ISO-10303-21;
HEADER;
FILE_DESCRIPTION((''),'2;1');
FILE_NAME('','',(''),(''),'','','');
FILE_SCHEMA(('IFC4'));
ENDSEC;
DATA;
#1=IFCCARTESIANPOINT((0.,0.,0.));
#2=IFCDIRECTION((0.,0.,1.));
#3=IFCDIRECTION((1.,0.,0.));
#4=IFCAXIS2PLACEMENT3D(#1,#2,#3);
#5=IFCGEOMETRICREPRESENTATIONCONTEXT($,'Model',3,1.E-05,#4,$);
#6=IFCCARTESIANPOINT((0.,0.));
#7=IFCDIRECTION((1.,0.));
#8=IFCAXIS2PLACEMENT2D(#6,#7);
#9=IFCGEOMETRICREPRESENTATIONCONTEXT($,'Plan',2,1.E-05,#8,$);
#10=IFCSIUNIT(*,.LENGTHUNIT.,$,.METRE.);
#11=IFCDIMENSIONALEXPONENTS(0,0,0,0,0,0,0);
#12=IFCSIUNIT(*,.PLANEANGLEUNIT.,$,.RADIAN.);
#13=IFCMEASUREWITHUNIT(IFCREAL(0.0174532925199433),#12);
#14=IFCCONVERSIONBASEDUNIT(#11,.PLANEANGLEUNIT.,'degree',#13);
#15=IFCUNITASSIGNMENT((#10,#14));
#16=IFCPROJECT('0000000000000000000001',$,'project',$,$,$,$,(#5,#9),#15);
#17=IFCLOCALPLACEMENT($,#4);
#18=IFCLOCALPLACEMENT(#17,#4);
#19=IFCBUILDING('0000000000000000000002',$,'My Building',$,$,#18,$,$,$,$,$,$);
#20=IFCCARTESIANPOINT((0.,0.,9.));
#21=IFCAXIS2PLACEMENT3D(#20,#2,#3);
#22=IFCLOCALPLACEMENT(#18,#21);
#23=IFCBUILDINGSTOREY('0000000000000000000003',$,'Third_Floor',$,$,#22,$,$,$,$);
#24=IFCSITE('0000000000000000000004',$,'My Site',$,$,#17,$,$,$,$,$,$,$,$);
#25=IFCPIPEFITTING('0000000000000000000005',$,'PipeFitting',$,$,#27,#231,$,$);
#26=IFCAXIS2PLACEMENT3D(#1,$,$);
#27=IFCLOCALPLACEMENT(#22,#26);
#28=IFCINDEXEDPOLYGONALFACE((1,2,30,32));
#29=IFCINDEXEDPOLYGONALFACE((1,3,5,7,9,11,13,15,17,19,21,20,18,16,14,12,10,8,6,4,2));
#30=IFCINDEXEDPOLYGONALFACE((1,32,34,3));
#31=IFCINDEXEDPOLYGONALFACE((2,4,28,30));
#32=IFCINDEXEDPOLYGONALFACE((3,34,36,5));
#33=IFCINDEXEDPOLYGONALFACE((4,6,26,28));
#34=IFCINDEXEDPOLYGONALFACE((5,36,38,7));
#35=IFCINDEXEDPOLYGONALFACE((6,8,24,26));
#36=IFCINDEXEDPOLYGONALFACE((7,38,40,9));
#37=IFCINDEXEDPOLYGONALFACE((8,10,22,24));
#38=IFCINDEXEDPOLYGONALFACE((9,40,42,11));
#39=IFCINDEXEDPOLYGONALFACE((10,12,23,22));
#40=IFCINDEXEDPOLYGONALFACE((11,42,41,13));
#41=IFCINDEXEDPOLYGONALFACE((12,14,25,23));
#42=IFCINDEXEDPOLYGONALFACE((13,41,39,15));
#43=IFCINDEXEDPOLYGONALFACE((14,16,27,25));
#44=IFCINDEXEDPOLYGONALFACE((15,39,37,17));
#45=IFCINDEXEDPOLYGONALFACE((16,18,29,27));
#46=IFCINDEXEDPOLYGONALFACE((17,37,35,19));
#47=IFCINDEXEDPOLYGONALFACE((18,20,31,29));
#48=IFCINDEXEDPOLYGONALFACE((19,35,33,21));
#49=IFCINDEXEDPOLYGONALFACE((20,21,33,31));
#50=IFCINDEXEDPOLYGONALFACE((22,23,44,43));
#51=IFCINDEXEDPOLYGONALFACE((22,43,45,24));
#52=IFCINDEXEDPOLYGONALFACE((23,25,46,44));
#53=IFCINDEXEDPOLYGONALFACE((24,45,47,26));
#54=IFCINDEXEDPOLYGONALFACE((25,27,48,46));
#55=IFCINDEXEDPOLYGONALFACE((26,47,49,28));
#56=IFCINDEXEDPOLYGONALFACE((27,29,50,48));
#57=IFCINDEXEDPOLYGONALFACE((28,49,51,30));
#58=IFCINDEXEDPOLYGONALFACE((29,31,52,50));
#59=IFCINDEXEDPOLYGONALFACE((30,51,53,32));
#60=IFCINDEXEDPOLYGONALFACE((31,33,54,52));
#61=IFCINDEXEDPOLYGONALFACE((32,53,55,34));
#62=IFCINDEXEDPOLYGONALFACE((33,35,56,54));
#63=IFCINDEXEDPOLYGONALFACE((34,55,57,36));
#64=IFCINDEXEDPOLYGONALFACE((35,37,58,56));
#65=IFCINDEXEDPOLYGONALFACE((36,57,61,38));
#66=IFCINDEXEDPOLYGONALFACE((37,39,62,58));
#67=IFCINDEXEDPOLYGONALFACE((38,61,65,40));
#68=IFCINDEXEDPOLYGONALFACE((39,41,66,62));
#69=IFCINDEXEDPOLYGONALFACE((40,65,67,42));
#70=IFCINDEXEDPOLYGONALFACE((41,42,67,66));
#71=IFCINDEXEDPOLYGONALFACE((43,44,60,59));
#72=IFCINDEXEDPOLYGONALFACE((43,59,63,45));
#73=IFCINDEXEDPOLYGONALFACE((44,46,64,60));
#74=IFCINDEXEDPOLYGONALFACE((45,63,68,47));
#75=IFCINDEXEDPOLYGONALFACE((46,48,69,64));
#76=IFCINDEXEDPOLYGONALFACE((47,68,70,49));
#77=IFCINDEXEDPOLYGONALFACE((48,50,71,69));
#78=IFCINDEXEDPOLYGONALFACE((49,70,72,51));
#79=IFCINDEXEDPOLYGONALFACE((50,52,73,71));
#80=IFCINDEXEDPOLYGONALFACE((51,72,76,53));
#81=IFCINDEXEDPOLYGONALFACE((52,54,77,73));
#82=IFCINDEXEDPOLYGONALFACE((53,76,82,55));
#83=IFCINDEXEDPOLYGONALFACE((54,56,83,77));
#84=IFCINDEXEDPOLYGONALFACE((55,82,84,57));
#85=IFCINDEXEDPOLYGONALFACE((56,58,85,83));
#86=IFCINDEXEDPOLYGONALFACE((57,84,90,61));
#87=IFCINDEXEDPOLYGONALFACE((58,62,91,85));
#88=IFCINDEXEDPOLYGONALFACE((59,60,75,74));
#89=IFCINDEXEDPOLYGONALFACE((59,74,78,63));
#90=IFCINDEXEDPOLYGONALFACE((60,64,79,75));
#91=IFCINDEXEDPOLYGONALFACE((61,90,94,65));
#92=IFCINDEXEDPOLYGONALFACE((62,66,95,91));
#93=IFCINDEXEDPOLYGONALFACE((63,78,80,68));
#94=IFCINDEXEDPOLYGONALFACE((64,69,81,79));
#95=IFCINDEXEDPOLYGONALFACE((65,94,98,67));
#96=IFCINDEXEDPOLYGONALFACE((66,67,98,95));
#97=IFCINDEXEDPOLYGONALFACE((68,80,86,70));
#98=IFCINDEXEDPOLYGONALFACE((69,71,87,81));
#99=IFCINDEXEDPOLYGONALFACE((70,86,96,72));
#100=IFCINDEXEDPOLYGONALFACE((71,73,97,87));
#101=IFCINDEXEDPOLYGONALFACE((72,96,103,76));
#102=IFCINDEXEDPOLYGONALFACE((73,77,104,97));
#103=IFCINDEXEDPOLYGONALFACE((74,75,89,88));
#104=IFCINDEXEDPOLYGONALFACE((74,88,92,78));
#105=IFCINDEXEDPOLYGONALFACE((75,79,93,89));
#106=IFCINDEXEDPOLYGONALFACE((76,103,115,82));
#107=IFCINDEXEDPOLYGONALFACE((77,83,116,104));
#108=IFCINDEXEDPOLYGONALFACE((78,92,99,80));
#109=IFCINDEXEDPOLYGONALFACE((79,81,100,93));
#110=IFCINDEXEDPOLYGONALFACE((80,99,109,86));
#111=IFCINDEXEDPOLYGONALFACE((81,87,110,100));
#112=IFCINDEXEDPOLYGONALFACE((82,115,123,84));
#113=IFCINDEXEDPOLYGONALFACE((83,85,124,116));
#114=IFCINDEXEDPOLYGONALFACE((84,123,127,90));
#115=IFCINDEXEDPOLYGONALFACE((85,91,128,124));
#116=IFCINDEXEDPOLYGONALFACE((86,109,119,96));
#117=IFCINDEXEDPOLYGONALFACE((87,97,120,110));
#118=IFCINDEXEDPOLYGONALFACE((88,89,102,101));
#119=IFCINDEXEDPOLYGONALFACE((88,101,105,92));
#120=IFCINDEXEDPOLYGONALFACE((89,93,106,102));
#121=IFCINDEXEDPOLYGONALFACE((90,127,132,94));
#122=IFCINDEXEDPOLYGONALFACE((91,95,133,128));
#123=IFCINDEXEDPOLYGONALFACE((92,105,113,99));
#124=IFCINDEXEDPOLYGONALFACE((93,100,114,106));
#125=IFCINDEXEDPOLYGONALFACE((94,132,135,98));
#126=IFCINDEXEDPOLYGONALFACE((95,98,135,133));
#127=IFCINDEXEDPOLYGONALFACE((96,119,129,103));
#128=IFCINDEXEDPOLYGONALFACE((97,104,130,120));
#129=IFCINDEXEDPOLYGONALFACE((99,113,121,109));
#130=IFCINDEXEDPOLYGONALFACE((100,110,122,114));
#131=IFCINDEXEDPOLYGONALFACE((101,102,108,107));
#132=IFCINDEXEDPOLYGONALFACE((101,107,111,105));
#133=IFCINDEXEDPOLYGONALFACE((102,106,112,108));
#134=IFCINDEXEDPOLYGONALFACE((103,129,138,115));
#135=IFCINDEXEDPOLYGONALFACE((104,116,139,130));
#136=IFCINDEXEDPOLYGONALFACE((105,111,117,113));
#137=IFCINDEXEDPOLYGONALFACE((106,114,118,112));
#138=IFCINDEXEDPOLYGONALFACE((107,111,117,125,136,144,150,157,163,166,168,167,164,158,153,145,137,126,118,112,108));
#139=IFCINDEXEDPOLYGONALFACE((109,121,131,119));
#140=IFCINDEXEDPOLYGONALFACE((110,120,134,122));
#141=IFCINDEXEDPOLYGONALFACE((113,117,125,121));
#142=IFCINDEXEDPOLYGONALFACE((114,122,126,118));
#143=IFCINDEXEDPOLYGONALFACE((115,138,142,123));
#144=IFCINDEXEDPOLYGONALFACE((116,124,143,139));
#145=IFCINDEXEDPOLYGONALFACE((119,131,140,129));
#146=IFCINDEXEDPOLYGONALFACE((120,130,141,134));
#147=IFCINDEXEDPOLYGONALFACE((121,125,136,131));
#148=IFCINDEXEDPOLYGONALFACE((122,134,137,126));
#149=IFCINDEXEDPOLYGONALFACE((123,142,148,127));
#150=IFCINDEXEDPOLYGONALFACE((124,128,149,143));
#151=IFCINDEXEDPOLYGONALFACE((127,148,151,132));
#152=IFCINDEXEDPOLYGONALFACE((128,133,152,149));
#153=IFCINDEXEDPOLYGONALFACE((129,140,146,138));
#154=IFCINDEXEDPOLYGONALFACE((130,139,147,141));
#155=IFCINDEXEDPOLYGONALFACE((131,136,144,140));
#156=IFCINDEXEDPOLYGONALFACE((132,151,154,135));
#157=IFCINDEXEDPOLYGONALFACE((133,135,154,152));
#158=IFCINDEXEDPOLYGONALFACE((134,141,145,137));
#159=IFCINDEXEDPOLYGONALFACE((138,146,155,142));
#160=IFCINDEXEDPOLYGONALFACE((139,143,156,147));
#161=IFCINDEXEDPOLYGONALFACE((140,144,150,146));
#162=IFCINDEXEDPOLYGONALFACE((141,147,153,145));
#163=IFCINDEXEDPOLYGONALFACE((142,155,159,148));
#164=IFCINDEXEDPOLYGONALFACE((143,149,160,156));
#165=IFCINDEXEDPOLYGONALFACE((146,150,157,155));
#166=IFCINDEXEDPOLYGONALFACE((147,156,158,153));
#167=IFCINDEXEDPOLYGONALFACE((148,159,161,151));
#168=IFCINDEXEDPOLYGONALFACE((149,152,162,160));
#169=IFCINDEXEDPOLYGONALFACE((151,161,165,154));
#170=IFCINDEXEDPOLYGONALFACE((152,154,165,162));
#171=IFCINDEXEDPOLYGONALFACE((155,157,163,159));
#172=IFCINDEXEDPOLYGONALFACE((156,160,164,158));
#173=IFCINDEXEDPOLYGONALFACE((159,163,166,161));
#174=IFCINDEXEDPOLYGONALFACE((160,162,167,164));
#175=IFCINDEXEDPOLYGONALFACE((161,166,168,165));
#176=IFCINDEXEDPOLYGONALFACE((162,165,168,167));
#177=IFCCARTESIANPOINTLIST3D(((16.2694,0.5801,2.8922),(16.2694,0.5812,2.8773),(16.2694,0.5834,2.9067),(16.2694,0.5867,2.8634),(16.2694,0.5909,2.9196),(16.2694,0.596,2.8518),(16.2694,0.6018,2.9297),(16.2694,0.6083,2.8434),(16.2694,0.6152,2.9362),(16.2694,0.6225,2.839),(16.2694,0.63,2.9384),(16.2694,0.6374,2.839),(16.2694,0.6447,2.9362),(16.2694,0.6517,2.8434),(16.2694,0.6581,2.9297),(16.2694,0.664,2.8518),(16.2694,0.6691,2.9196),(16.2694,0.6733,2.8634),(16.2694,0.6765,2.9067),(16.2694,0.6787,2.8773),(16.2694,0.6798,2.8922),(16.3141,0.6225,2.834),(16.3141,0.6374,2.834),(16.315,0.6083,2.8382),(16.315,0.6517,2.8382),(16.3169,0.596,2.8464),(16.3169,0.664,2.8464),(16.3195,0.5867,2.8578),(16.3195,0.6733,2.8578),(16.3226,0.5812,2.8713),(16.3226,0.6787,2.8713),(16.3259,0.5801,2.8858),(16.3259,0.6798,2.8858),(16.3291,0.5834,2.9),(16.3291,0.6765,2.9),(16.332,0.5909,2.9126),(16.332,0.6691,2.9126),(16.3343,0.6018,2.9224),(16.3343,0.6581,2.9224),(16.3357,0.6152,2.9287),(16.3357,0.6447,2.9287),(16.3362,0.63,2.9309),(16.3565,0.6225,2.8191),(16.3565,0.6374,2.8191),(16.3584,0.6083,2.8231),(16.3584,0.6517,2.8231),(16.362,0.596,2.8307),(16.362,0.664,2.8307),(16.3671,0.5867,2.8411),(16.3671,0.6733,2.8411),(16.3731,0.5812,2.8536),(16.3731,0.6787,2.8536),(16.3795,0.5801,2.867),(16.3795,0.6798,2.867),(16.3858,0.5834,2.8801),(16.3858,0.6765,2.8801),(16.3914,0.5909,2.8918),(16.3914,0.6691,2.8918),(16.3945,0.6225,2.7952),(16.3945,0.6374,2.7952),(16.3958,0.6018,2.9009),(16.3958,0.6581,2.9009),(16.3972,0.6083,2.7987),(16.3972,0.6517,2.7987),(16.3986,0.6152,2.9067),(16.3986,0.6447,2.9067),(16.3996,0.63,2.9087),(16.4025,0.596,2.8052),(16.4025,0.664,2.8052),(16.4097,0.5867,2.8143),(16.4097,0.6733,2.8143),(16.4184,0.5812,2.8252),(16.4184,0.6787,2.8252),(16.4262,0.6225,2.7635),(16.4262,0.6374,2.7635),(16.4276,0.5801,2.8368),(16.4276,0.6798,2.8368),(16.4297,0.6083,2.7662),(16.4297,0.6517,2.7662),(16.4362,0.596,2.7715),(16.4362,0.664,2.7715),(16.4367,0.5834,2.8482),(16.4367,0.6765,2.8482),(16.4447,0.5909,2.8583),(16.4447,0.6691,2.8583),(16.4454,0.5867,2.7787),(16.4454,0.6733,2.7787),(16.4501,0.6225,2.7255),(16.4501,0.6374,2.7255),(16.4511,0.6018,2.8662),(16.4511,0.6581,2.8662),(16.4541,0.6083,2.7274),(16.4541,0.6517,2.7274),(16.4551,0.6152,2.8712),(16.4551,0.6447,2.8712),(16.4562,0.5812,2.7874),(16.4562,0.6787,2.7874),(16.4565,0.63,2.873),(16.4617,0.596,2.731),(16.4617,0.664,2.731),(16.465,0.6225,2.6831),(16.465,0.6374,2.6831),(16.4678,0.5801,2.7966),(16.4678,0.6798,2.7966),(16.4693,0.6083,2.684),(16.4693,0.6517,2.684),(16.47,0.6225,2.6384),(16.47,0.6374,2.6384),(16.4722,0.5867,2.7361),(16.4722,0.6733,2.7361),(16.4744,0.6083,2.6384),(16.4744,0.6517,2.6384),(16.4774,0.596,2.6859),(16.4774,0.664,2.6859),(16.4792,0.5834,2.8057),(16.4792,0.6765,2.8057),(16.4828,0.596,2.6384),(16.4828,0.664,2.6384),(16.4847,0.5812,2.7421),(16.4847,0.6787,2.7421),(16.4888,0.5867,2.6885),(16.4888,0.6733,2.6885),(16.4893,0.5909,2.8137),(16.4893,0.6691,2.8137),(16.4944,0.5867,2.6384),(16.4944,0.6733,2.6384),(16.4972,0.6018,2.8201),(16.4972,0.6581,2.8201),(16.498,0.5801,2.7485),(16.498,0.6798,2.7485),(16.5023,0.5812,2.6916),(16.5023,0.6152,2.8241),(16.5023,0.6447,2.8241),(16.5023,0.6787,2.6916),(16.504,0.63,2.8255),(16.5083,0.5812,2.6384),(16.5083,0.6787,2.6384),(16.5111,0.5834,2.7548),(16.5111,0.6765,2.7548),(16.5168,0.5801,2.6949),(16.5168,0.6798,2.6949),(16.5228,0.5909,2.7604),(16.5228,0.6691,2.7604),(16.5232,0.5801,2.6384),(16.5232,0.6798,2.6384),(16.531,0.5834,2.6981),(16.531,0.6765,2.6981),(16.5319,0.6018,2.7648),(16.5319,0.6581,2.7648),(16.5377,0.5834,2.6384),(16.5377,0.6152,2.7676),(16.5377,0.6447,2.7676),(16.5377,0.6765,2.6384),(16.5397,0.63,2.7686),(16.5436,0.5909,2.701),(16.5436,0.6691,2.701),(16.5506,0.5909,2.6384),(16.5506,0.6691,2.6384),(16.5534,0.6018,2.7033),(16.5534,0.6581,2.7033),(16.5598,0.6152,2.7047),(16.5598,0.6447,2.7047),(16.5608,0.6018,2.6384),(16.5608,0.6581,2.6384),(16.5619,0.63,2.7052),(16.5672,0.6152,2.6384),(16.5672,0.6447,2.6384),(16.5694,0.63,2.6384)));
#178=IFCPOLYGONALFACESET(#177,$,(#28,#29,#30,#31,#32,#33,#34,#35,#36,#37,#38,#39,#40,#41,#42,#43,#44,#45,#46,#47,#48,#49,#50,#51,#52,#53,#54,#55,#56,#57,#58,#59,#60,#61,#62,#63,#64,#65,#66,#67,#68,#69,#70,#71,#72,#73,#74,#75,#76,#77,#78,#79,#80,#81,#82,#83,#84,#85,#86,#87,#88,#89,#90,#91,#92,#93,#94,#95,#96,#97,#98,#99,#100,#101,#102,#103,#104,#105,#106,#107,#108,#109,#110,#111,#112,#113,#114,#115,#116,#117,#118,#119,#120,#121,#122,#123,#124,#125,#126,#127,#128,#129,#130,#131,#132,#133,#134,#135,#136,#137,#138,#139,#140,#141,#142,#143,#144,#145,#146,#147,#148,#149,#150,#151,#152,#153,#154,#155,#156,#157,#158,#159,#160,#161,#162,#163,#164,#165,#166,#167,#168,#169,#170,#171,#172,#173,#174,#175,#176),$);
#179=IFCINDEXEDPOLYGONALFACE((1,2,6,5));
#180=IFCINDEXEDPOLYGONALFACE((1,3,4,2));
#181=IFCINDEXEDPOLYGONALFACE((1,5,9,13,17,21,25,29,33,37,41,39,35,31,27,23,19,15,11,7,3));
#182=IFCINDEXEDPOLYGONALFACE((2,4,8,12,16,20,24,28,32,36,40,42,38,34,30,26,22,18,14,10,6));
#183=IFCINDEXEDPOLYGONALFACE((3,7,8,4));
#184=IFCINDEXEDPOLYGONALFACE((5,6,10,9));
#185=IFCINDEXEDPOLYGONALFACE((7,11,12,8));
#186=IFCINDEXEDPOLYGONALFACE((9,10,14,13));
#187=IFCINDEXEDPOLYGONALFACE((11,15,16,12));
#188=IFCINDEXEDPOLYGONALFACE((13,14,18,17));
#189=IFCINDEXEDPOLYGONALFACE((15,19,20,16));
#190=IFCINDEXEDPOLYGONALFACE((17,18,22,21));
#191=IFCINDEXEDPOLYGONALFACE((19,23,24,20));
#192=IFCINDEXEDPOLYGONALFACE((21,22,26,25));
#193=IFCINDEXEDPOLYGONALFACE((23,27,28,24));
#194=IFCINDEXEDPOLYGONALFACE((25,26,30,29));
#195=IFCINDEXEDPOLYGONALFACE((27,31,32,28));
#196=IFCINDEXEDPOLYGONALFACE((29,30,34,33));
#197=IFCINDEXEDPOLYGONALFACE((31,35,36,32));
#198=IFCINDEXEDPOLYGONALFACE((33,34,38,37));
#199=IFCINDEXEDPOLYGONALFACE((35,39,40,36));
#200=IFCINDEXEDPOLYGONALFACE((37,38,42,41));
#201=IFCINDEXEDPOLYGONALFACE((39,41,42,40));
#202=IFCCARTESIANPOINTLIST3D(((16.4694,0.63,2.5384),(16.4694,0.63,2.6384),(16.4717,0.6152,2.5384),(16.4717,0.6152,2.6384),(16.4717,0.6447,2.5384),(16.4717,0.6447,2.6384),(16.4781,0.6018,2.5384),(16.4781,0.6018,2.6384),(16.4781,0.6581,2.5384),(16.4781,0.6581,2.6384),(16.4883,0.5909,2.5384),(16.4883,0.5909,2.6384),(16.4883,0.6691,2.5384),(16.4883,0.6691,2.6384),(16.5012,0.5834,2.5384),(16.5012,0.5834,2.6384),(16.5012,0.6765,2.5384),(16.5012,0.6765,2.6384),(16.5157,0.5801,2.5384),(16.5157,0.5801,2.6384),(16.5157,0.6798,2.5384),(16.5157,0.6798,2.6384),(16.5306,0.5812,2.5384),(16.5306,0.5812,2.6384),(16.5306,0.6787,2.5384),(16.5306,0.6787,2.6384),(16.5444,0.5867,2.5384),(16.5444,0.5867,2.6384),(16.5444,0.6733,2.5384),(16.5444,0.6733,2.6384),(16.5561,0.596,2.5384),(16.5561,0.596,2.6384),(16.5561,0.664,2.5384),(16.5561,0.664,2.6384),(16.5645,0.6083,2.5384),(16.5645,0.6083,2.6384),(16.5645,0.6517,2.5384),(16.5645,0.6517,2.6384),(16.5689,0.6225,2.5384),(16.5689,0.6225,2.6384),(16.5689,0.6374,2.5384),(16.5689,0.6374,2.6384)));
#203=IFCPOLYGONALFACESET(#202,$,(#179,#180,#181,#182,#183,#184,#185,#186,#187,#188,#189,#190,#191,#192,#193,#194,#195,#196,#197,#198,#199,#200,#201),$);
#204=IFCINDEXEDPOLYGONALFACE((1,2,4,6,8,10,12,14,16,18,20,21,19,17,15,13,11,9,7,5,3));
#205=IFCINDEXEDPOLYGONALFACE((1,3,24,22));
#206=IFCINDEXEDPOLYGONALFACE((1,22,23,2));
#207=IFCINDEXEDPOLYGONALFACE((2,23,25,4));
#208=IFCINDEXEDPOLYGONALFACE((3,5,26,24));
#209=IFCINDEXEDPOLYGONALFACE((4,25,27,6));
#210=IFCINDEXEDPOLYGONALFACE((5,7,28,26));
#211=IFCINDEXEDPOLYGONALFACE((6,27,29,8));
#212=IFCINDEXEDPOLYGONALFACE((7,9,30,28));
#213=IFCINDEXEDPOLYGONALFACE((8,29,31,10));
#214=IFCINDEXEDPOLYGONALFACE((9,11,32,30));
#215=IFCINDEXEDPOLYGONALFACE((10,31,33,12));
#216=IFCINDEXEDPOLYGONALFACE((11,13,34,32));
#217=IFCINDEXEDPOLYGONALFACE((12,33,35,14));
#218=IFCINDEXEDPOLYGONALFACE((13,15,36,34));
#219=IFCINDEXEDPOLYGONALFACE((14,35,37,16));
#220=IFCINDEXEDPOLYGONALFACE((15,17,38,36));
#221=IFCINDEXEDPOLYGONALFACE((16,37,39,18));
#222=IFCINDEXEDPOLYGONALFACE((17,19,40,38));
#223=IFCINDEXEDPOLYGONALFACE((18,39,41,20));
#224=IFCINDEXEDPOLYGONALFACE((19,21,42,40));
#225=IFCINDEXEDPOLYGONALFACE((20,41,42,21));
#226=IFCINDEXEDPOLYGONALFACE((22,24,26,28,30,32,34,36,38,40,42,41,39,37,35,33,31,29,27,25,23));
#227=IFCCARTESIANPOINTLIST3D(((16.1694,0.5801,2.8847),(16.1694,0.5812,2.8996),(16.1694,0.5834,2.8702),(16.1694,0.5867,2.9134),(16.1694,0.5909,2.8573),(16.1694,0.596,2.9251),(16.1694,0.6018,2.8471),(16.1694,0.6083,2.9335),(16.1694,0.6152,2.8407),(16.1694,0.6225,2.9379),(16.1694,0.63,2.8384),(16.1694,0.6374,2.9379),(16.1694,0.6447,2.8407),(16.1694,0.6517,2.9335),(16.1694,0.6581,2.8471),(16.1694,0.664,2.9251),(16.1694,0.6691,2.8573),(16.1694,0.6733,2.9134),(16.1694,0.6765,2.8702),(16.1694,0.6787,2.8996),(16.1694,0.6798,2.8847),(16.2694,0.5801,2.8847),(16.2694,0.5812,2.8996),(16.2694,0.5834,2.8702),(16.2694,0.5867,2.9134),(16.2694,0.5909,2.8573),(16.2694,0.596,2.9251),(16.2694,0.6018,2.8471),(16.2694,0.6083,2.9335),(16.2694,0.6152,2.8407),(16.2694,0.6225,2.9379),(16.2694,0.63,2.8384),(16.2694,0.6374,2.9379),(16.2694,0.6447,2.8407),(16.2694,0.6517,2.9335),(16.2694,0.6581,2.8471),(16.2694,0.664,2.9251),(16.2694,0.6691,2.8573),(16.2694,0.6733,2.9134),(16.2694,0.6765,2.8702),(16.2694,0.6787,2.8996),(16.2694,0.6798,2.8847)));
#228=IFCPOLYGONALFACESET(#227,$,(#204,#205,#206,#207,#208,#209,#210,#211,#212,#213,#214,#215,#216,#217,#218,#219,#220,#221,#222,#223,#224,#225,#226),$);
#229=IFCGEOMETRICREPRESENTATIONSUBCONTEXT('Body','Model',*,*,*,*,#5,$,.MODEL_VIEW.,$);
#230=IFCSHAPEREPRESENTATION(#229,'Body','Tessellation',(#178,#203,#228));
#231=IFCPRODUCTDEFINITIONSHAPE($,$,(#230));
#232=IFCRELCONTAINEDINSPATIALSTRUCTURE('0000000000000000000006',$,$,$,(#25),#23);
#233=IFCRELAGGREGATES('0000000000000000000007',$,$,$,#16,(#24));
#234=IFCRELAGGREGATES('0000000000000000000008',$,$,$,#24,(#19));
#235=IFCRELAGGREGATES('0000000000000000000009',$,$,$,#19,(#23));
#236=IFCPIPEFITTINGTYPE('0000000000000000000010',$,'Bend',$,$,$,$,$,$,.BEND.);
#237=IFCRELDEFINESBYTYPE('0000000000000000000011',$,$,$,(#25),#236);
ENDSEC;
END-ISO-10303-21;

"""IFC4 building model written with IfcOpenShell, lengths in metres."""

from ifc_helpers import new_model, entity, si_unit, converted_unit, frame, origin_with_axes, origin_2d_with_axis, place, context, subcontext, project, spatial, circle, extrude, source, transform, mapped, type_object, type_shapes, element, save


model = new_model("IFC4")

# Units and contexts
model_context = context("Model", 3, precision=1e-05, world=origin_with_axes())
plan_context = context("Plan", 2, precision=1e-05, world=origin_2d_with_axis())
body_context = subcontext(model_context, "Body", "Model", "MODEL_VIEW")
ifc_project = project(units=[si_unit("LENGTHUNIT", "METRE"), converted_unit("PLANEANGLEUNIT", "degree", entity("IfcReal", 0.0174532925199433), si_unit("PLANEANGLEUNIT", "RADIAN"), dimensions=[0, 0, 0, 0, 0, 0, 0])], contexts=[model_context, plan_context])

# Site, building, storey
site_placement = place(None, origin_with_axes())
site = spatial("IfcSite", under=ifc_project, at=site_placement, Name="My Site")
building_placement = place(site_placement, origin_with_axes())
building = spatial("IfcBuilding", under=site, at=building_placement, Name="My Building")
storey_placement = place(building_placement, frame((0.0, 0.0, 9.0), z_axis=(0.0, 0.0, 1.0), x_axis=(1.0, 0.0, 0.0)))
storey = spatial("IfcBuildingStorey", under=building, at=storey_placement, Name="Third_Floor")

# Pipe fitting
pipe_fitting_type = type_object("IfcPipeFittingType", Name="Bend", PredefinedType="BEND")
shared_shape = source(origin_with_axes(), body_context, "Body", "SolidModel", [
    entity("IfcSweptDiskSolid", entity("IfcIndexedPolyCurve", entity("IfcCartesianPointList3D", [[0.0, 0.0, -0.1], [0.0732, 0.0, -0.2768], [0.25, 0.0, -0.35]]), [entity("IfcArcIndex", [1, 2, 3])]), 0.05),
    extrude(circle(Radius=0.05), origin_with_axes(), (0.0, 0.0, -1.0), 0.1),
    extrude(circle(Radius=0.05), frame((0.25, 0.0, -0.35), z_axis=(1.0, 0.0, 0.0), x_axis=(0.0, 0.0, 1.0)), (0.0, 0.0, 1.0), 0.1),
])
type_shapes(pipe_fitting_type, [shared_shape])
for number, where, z_axis, x_axis, name in (
    (1, (16.5194, 0.63, 2.5384), (0.000001, 0.0, -1.0), (-1.0, -0.000001, -0.000001), "PipeFitting"),
):
    element("IfcPipeFitting", number, at=place(storey_placement, frame(where, z_axis=z_axis, x_axis=x_axis)), inside=storey, type_object=pipe_fitting_type, Name=name, context=body_context, shape_type="MappedRepresentation", body=[
        mapped(shared_shape, transform((0.0, 0.0, 0.0), x_axis=(1.0, 0.0, 0.0), y_axis=(0.0, 1.0, 0.0), z_axis=(0.0, 0.0, 1.0), scale=1.0)),
    ])

save(model, "model.ifc")
